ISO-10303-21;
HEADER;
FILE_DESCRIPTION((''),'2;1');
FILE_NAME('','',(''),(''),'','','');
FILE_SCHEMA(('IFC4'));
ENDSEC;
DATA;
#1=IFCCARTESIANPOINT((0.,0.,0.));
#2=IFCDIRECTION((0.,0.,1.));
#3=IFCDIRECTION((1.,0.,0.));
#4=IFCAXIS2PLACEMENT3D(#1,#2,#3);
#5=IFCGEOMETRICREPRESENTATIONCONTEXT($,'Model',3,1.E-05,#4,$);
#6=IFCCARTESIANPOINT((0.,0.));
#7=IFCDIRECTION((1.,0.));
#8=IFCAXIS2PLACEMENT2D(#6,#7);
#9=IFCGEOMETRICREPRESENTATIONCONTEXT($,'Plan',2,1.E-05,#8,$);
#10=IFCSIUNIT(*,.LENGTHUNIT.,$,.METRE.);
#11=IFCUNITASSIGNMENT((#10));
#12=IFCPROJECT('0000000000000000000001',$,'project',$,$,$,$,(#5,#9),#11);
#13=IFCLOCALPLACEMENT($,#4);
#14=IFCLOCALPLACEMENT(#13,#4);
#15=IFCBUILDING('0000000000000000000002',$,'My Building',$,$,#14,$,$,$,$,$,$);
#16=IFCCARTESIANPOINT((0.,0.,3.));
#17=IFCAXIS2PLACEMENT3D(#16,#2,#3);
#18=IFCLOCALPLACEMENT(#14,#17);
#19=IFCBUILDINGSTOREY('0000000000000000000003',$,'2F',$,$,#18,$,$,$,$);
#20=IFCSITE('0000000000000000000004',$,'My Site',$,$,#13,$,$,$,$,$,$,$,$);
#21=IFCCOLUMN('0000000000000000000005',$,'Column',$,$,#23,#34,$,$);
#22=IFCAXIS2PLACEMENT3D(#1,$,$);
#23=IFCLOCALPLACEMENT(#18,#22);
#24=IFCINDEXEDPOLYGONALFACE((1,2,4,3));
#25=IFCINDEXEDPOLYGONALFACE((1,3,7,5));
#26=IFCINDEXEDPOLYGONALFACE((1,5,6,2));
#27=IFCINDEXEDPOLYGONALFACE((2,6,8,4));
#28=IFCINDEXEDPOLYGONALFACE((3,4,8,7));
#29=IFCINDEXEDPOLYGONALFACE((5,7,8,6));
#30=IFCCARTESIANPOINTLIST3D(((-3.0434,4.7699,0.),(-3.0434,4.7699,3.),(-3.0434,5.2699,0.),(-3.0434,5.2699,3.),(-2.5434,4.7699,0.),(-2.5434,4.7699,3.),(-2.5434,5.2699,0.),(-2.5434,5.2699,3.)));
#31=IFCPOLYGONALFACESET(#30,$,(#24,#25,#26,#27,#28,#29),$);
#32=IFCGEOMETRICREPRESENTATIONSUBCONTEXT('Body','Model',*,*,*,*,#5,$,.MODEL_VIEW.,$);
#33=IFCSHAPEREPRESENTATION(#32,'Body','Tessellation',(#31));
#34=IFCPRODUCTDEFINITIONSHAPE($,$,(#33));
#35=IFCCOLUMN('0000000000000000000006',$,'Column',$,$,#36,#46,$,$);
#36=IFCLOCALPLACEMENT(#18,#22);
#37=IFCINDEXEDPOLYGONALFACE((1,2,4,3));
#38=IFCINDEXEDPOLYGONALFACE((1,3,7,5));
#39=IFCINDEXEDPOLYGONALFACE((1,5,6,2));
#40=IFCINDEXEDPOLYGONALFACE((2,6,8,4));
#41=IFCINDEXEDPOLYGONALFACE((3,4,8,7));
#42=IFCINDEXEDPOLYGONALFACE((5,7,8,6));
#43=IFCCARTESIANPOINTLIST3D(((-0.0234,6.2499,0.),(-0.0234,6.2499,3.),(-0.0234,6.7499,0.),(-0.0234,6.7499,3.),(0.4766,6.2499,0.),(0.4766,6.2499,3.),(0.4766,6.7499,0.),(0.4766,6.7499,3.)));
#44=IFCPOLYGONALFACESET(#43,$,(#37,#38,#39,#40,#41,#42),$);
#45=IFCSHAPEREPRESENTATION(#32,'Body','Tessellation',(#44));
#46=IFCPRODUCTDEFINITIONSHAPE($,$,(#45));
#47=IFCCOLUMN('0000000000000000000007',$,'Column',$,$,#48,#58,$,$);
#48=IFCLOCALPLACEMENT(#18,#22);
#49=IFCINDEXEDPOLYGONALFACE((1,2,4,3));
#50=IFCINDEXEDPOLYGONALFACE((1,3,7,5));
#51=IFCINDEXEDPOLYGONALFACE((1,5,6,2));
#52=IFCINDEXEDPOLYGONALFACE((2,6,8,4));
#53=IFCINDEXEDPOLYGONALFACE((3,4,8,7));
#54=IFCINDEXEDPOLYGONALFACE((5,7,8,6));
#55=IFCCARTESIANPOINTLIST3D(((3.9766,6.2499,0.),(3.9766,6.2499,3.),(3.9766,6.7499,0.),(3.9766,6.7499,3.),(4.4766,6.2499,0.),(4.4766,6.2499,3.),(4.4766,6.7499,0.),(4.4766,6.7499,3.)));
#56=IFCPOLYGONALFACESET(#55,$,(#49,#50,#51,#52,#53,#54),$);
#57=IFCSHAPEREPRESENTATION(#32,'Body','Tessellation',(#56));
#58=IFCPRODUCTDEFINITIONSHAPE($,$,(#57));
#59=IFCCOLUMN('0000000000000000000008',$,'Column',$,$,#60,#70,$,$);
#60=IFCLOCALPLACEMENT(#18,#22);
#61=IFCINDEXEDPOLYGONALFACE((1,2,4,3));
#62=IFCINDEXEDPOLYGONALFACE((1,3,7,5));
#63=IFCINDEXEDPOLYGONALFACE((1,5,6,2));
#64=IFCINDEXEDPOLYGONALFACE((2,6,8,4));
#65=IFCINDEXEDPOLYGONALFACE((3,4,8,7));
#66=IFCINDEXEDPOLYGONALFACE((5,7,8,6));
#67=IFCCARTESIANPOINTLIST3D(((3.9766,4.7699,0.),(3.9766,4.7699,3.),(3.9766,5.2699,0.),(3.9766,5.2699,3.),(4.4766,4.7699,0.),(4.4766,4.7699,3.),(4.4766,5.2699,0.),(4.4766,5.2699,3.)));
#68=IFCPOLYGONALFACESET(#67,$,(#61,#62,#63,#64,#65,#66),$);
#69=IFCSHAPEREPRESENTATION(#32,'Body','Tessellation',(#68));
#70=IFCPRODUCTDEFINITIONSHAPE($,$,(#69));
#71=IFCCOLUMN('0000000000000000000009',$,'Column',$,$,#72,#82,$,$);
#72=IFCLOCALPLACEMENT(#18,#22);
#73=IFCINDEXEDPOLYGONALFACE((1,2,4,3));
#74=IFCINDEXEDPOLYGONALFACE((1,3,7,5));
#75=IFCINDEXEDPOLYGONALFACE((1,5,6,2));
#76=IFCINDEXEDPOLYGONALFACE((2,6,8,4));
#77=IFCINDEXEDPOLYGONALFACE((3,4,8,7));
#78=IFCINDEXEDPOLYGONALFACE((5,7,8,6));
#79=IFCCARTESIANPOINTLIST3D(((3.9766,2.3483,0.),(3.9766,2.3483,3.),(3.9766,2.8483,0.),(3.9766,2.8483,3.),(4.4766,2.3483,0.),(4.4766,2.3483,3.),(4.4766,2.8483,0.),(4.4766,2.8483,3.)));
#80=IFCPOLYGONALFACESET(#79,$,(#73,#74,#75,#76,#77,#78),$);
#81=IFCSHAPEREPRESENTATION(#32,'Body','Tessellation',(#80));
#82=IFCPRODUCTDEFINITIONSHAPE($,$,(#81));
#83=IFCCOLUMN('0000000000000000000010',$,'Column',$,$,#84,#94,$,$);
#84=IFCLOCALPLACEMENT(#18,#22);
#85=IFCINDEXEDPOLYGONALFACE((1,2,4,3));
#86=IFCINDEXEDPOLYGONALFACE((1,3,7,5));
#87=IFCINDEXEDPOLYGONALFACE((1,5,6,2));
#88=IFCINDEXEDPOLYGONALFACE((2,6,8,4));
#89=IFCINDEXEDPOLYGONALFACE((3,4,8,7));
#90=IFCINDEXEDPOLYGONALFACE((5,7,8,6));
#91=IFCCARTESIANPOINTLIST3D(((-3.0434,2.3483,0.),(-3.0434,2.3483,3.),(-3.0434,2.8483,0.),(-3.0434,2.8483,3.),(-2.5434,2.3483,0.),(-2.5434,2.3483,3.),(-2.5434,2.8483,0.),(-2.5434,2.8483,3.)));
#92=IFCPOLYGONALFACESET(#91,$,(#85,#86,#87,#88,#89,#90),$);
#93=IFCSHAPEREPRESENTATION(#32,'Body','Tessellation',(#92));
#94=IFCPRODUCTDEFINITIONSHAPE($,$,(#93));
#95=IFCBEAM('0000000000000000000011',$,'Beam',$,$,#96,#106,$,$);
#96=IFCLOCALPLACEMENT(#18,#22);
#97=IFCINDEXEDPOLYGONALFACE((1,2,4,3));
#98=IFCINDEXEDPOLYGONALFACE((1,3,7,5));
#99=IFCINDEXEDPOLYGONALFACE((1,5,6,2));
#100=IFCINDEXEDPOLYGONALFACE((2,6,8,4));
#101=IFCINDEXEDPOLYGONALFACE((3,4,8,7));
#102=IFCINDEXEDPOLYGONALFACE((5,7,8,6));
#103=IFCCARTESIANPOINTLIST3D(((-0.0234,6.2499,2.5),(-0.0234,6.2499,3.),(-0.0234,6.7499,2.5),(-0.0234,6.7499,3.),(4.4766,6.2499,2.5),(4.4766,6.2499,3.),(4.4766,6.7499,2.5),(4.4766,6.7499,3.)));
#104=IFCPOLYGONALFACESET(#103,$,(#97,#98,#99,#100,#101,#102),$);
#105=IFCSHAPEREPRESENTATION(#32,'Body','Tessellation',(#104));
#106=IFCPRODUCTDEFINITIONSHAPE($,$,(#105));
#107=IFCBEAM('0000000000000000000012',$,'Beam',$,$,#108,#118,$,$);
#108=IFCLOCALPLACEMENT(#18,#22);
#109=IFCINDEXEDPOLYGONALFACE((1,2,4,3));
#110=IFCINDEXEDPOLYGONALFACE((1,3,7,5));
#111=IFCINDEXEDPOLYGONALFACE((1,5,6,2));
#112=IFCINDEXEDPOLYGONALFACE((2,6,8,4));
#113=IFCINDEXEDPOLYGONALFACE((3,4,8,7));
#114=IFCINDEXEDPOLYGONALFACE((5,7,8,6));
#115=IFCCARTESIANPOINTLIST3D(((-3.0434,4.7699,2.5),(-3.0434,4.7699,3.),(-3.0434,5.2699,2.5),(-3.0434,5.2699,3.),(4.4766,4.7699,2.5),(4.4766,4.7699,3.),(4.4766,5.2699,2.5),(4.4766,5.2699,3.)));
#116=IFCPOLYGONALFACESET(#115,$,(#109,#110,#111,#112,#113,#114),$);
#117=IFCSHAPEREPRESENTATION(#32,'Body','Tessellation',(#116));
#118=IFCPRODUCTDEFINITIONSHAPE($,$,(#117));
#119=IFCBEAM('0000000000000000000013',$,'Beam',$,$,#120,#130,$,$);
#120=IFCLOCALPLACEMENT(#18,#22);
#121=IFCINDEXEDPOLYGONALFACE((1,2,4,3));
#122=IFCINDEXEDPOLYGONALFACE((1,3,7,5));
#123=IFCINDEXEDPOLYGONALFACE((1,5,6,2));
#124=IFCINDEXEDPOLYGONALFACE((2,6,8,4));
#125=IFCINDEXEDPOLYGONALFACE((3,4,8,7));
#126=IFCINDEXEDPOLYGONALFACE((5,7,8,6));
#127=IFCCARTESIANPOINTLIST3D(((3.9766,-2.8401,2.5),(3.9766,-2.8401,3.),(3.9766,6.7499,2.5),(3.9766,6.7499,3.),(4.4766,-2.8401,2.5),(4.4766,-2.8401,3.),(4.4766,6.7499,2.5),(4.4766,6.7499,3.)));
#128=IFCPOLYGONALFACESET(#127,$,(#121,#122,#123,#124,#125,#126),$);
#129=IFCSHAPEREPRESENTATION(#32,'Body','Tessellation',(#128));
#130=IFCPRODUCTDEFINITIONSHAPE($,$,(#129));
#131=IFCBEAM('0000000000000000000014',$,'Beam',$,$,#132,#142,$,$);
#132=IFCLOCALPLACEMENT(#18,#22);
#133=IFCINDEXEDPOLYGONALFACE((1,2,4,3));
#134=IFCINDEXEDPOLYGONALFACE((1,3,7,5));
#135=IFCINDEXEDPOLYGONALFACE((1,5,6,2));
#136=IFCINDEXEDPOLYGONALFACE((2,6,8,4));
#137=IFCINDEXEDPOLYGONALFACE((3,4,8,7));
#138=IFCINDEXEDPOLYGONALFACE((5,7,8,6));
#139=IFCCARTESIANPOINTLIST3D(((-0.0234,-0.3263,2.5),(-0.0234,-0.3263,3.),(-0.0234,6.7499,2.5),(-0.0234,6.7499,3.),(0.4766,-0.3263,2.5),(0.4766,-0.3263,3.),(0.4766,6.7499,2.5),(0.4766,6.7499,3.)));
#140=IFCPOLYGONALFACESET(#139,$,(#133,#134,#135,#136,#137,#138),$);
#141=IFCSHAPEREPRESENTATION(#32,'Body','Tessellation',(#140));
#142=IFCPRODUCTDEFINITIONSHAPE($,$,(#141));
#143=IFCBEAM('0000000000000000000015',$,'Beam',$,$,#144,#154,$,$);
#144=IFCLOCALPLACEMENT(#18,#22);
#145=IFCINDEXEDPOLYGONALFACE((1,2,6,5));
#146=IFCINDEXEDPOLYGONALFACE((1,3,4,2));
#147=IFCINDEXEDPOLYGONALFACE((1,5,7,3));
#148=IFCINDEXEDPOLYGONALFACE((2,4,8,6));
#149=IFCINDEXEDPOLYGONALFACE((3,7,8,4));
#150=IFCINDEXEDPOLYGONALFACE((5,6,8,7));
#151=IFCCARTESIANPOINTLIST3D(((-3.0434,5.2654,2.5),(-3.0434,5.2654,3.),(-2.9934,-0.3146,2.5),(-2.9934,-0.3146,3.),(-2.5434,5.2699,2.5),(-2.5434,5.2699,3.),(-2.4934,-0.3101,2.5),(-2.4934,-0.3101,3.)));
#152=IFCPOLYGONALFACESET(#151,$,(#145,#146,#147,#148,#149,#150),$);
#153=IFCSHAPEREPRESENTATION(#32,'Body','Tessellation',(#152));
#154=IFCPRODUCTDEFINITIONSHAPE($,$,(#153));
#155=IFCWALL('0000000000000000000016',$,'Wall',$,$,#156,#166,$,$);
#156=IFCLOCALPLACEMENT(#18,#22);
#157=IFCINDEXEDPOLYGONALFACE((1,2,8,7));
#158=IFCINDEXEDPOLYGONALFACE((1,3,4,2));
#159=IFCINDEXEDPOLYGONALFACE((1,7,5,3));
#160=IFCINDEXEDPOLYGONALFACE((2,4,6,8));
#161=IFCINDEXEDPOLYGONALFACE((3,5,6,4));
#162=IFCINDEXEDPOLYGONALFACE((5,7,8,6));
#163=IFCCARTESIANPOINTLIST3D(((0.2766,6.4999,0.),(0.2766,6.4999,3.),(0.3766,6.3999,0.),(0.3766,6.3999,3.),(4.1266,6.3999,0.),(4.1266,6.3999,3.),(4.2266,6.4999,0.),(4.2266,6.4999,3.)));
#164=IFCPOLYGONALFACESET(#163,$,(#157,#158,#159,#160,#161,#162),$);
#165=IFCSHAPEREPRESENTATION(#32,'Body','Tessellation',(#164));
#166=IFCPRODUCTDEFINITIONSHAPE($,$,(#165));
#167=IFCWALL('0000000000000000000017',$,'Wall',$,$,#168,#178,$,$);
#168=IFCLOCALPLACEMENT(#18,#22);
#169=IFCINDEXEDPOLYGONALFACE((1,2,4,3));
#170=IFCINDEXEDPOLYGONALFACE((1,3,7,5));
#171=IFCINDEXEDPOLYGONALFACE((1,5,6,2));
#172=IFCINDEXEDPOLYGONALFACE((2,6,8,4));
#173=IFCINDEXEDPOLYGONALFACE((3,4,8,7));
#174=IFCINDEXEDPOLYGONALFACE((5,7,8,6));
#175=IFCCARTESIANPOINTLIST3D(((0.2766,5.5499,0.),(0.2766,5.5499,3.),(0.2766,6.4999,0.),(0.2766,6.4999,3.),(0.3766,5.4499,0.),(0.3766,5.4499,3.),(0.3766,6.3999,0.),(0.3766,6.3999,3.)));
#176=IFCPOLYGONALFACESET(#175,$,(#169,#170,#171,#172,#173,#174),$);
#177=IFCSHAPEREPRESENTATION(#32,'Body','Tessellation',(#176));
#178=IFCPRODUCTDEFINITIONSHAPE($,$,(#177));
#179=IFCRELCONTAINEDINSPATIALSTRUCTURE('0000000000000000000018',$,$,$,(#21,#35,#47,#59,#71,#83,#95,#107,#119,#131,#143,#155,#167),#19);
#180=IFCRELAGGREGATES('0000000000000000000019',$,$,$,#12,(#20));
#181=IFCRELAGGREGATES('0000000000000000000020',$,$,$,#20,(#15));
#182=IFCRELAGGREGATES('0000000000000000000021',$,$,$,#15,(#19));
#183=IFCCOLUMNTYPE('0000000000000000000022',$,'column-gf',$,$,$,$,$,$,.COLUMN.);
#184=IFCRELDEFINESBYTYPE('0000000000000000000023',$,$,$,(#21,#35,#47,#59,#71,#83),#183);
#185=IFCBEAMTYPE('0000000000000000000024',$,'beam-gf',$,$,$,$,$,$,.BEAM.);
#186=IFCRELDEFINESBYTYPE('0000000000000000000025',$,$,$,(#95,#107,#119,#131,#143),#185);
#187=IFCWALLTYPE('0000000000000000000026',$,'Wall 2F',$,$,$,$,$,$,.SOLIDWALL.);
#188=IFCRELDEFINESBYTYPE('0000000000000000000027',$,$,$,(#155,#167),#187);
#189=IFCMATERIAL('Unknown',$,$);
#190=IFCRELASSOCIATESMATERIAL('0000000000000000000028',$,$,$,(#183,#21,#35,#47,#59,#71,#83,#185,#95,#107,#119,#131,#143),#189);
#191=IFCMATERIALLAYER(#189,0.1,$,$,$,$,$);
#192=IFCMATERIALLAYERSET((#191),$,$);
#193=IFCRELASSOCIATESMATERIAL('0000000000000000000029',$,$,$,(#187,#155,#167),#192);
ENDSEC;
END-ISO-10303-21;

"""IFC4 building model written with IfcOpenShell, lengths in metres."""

from ifc_helpers import new_model, si_unit, frame, origin_with_axes, origin_2d_with_axis, place, context, subcontext, project, spatial, line, indexed_curve, rectangle, outline, extrude, material, layer, layer_set, layer_usage, material_profile, profile_set, profile_usage, type_object, element, save


model = new_model("IFC4")

# Units and contexts
model_context = context("Model", 3, precision=1e-05, world=origin_with_axes())
plan_context = context("Plan", 2, precision=1e-05, world=origin_2d_with_axis())
body_context_1 = subcontext(model_context, "Body", "Model", "MODEL_VIEW")
ifc_project = project(units=[si_unit("LENGTHUNIT", "METRE")], contexts=[model_context, plan_context])

# Site, building, storey
site_placement = place(None, origin_with_axes())
site = spatial("IfcSite", under=ifc_project, at=site_placement, Name="My Site")
building_placement = place(site_placement, origin_with_axes())
building = spatial("IfcBuilding", under=site, at=building_placement, Name="My Building")
storey_placement = place(building_placement, frame((0.0, 0.0, 3.0), z_axis=(0.0, 0.0, 1.0), x_axis=(1.0, 0.0, 0.0)))
storey = spatial("IfcBuildingStorey", under=building, at=storey_placement, Name="2F")

# Columns
ifc_material = material(Name="Unknown")
ifc_material_profile_1 = material_profile(ifc_material, rectangle(XDim=0.5, YDim=0.5))
ifc_profile_set_1 = profile_set([ifc_material_profile_1])
ifc_profile_usage_1 = profile_usage(ifc_profile_set_1, cardinal=7)
column_type = type_object("IfcColumnType", Name="column-gf", PredefinedType="COLUMN", material=ifc_profile_set_1)
column_1_placement = place(storey_placement, frame((-2.5434, 5.2699, 0.0), z_axis=(0.0, 0.0, 1.0), x_axis=(1.0, 0.0, 0.0)))
element("IfcColumn", 1, at=column_1_placement, inside=storey, type_object=column_type, material=ifc_profile_usage_1, Name="Column", context=body_context_1, shape_type="SweptSolid", body=[
    extrude(rectangle(XDim=0.5, YDim=0.5), frame((-0.25, -0.25, 0.0), z_axis=(0.0, 0.0, 1.0), x_axis=(1.0, 0.0, 0.0)), (0.0, 0.0, 1.0), 3.0),
])
ifc_profile_usage_2 = profile_usage(ifc_profile_set_1, cardinal=7)
column_2_placement = place(storey_placement, frame((0.4766, 6.7499, 0.0), z_axis=(0.0, 0.0, 1.0), x_axis=(1.0, 0.0, 0.0)))
element("IfcColumn", 2, at=column_2_placement, inside=storey, type_object=column_type, material=ifc_profile_usage_2, Name="Column", context=body_context_1, shape_type="SweptSolid", body=[
    extrude(rectangle(XDim=0.5, YDim=0.5), frame((-0.25, -0.25, 0.0), z_axis=(0.0, 0.0, 1.0), x_axis=(1.0, 0.0, 0.0)), (0.0, 0.0, 1.0), 3.0),
])
ifc_profile_usage_3 = profile_usage(ifc_profile_set_1, cardinal=7)
column_3_placement = place(storey_placement, frame((4.4766, 6.7499, 0.0), z_axis=(0.0, 0.0, 1.0), x_axis=(1.0, 0.0, 0.0)))
element("IfcColumn", 3, at=column_3_placement, inside=storey, type_object=column_type, material=ifc_profile_usage_3, Name="Column", context=body_context_1, shape_type="SweptSolid", body=[
    extrude(rectangle(XDim=0.5, YDim=0.5), frame((-0.25, -0.25, 0.0), z_axis=(0.0, 0.0, 1.0), x_axis=(1.0, 0.0, 0.0)), (0.0, 0.0, 1.0), 3.0),
])
ifc_profile_usage_4 = profile_usage(ifc_profile_set_1, cardinal=7)
column_4_placement = place(storey_placement, frame((4.4766, 5.2699, 0.0), z_axis=(0.0, 0.0, 1.0), x_axis=(1.0, 0.0, 0.0)))
element("IfcColumn", 4, at=column_4_placement, inside=storey, type_object=column_type, material=ifc_profile_usage_4, Name="Column", context=body_context_1, shape_type="SweptSolid", body=[
    extrude(rectangle(XDim=0.5, YDim=0.5), frame((-0.25, -0.25, 0.0), z_axis=(0.0, 0.0, 1.0), x_axis=(1.0, 0.0, 0.0)), (0.0, 0.0, 1.0), 3.0),
])
ifc_profile_usage_5 = profile_usage(ifc_profile_set_1, cardinal=7)
column_5_placement = place(storey_placement, frame((4.4766, 2.8483, 0.0), z_axis=(0.0, 0.0, 1.0), x_axis=(1.0, 0.0, 0.0)))
element("IfcColumn", 5, at=column_5_placement, inside=storey, type_object=column_type, material=ifc_profile_usage_5, Name="Column", context=body_context_1, shape_type="SweptSolid", body=[
    extrude(rectangle(XDim=0.5, YDim=0.5), frame((-0.25, -0.25, 0.0), z_axis=(0.0, 0.0, 1.0), x_axis=(1.0, 0.0, 0.0)), (0.0, 0.0, 1.0), 3.0),
])
ifc_profile_usage_6 = profile_usage(ifc_profile_set_1, cardinal=7)
column_6_placement = place(storey_placement, frame((-2.5434, 2.8483, 0.0), z_axis=(0.0, 0.0, 1.0), x_axis=(1.0, 0.0, 0.0)))
element("IfcColumn", 6, at=column_6_placement, inside=storey, type_object=column_type, material=ifc_profile_usage_6, Name="Column", context=body_context_1, shape_type="SweptSolid", body=[
    extrude(rectangle(XDim=0.5, YDim=0.5), frame((-0.25, -0.25, 0.0), z_axis=(0.0, 0.0, 1.0), x_axis=(1.0, 0.0, 0.0)), (0.0, 0.0, 1.0), 3.0),
])

# Beams
ifc_material_profile_2 = material_profile(ifc_material, rectangle(XDim=0.5, YDim=0.5))
ifc_profile_set_2 = profile_set([ifc_material_profile_2])
ifc_profile_usage_7 = profile_usage(ifc_profile_set_2, cardinal=7)
beam_type = type_object("IfcBeamType", Name="beam-gf", PredefinedType="BEAM", material=ifc_profile_set_2)
beam_1_placement = place(storey_placement, frame((4.4766, 6.2499, 3.0), z_axis=(-1.0, -0.000001, 0.000001), x_axis=(0.000001, -1.0, 0.0)))
element("IfcBeam", 7, at=beam_1_placement, inside=storey, type_object=beam_type, material=ifc_profile_usage_7, Name="Beam", context=body_context_1, shape_type="SweptSolid", body=[
    extrude(rectangle(XDim=0.5, YDim=0.5), frame((-0.25, -0.25, 0.0), z_axis=(0.0, 0.0, 1.0), x_axis=(1.0, 0.0, 0.0)), (0.0, 0.0, 1.0), 4.5),
])
ifc_profile_usage_8 = profile_usage(ifc_profile_set_2, cardinal=7)
beam_2_placement = place(storey_placement, frame((4.4766, 4.7699, 3.0), z_axis=(-1.0, 0.0, 0.0), x_axis=(0.0, -1.0, 0.0)))
element("IfcBeam", 8, at=beam_2_placement, inside=storey, type_object=beam_type, material=ifc_profile_usage_8, Name="Beam", context=body_context_1, shape_type="SweptSolid", body=[
    extrude(rectangle(XDim=0.5, YDim=0.5), frame((-0.25, -0.25, 0.0), z_axis=(0.0, 0.0, 1.0), x_axis=(1.0, 0.0, 0.0)), (0.0, 0.0, 1.0), 7.52),
])
ifc_profile_usage_9 = profile_usage(ifc_profile_set_2, cardinal=7)
beam_3_placement = place(storey_placement, frame((4.4766, 6.7499, 3.0), z_axis=(0.0, -1.0, 0.0), x_axis=(1.0, 0.0, 0.0)))
element("IfcBeam", 9, at=beam_3_placement, inside=storey, type_object=beam_type, material=ifc_profile_usage_9, Name="Beam", context=body_context_1, shape_type="SweptSolid", body=[
    extrude(rectangle(XDim=0.5, YDim=0.5), frame((-0.25, -0.25, 0.0), z_axis=(0.0, 0.0, 1.0), x_axis=(1.0, 0.0, 0.0)), (0.0, 0.0, 1.0), 9.59),
])
ifc_profile_usage_10 = profile_usage(ifc_profile_set_2, cardinal=7)
beam_4_placement = place(storey_placement, frame((0.4766, 6.7499, 3.0), z_axis=(0.0, -1.0, 0.0), x_axis=(1.0, 0.0, 0.0)))
element("IfcBeam", 10, at=beam_4_placement, inside=storey, type_object=beam_type, material=ifc_profile_usage_10, Name="Beam", context=body_context_1, shape_type="SweptSolid", body=[
    extrude(rectangle(XDim=0.5, YDim=0.5), frame((-0.25, -0.25, 0.0), z_axis=(0.0, 0.0, 1.0), x_axis=(1.0, 0.0, 0.0)), (0.0, 0.0, 1.0), 7.0762),
])
ifc_profile_usage_11 = profile_usage(ifc_profile_set_2, cardinal=7)
beam_5_placement = place(storey_placement, frame((-2.5434, 5.2699, 3.0), z_axis=(0.00896, -0.99996, 0.0), x_axis=(0.99996, 0.00896, 0.0)))
element("IfcBeam", 11, at=beam_5_placement, inside=storey, type_object=beam_type, material=ifc_profile_usage_11, Name="Beam", context=body_context_1, shape_type="SweptSolid", body=[
    extrude(rectangle(XDim=0.5, YDim=0.5), frame((-0.25, -0.25, 0.0), z_axis=(0.0, 0.0, 1.0), x_axis=(1.0, 0.0, 0.0)), (0.0, 0.0, 1.0), 5.5802),
])

# Walls
ifc_layer = layer(ifc_material, 0.1)
ifc_layer_set = layer_set([ifc_layer])
ifc_layer_usage_1 = layer_usage(ifc_layer_set, "AXIS2", "POSITIVE", 0.0)
wall_type = type_object("IfcWallType", Name="Wall 2F", PredefinedType="SOLIDWALL", material=ifc_layer_set)
wall_1_placement = place(storey_placement, frame((4.2266, 6.4999, 0.0), z_axis=(0.0, 0.0, 1.0), x_axis=(-1.0, 0.0, 0.0)))
element("IfcWall", 12, at=wall_1_placement, inside=storey, type_object=wall_type, material=ifc_layer_usage_1, Name="Wall", context=body_context_1, shape_type="SweptSolid", body=[
    extrude(outline(indexed_curve([(0.0, 0.0), (0.1, 0.1), (3.85, 0.1), (3.95, 0.0)], segments=[line(1, 2, 3, 4, 1)])), origin_with_axes(), (0.0, 0.0, 1.0), 3.0),
])
ifc_layer_usage_2 = layer_usage(ifc_layer_set, "AXIS2", "POSITIVE", 0.0)
wall_2_placement = place(storey_placement, frame((0.2766, 6.4999, 0.0), z_axis=(0.0, 0.0, 1.0), x_axis=(0.0, -1.0, 0.0)))
element("IfcWall", 13, at=wall_2_placement, inside=storey, type_object=wall_type, material=ifc_layer_usage_2, Name="Wall", context=body_context_1, shape_type="SweptSolid", body=[
    extrude(outline(indexed_curve([(0.0, 0.0), (0.1, 0.1), (1.05, 0.1), (0.95, 0.0)], segments=[line(1, 2, 3, 4, 1)])), origin_with_axes(), (0.0, 0.0, 1.0), 3.0),
])

save(model, "model.ifc")
